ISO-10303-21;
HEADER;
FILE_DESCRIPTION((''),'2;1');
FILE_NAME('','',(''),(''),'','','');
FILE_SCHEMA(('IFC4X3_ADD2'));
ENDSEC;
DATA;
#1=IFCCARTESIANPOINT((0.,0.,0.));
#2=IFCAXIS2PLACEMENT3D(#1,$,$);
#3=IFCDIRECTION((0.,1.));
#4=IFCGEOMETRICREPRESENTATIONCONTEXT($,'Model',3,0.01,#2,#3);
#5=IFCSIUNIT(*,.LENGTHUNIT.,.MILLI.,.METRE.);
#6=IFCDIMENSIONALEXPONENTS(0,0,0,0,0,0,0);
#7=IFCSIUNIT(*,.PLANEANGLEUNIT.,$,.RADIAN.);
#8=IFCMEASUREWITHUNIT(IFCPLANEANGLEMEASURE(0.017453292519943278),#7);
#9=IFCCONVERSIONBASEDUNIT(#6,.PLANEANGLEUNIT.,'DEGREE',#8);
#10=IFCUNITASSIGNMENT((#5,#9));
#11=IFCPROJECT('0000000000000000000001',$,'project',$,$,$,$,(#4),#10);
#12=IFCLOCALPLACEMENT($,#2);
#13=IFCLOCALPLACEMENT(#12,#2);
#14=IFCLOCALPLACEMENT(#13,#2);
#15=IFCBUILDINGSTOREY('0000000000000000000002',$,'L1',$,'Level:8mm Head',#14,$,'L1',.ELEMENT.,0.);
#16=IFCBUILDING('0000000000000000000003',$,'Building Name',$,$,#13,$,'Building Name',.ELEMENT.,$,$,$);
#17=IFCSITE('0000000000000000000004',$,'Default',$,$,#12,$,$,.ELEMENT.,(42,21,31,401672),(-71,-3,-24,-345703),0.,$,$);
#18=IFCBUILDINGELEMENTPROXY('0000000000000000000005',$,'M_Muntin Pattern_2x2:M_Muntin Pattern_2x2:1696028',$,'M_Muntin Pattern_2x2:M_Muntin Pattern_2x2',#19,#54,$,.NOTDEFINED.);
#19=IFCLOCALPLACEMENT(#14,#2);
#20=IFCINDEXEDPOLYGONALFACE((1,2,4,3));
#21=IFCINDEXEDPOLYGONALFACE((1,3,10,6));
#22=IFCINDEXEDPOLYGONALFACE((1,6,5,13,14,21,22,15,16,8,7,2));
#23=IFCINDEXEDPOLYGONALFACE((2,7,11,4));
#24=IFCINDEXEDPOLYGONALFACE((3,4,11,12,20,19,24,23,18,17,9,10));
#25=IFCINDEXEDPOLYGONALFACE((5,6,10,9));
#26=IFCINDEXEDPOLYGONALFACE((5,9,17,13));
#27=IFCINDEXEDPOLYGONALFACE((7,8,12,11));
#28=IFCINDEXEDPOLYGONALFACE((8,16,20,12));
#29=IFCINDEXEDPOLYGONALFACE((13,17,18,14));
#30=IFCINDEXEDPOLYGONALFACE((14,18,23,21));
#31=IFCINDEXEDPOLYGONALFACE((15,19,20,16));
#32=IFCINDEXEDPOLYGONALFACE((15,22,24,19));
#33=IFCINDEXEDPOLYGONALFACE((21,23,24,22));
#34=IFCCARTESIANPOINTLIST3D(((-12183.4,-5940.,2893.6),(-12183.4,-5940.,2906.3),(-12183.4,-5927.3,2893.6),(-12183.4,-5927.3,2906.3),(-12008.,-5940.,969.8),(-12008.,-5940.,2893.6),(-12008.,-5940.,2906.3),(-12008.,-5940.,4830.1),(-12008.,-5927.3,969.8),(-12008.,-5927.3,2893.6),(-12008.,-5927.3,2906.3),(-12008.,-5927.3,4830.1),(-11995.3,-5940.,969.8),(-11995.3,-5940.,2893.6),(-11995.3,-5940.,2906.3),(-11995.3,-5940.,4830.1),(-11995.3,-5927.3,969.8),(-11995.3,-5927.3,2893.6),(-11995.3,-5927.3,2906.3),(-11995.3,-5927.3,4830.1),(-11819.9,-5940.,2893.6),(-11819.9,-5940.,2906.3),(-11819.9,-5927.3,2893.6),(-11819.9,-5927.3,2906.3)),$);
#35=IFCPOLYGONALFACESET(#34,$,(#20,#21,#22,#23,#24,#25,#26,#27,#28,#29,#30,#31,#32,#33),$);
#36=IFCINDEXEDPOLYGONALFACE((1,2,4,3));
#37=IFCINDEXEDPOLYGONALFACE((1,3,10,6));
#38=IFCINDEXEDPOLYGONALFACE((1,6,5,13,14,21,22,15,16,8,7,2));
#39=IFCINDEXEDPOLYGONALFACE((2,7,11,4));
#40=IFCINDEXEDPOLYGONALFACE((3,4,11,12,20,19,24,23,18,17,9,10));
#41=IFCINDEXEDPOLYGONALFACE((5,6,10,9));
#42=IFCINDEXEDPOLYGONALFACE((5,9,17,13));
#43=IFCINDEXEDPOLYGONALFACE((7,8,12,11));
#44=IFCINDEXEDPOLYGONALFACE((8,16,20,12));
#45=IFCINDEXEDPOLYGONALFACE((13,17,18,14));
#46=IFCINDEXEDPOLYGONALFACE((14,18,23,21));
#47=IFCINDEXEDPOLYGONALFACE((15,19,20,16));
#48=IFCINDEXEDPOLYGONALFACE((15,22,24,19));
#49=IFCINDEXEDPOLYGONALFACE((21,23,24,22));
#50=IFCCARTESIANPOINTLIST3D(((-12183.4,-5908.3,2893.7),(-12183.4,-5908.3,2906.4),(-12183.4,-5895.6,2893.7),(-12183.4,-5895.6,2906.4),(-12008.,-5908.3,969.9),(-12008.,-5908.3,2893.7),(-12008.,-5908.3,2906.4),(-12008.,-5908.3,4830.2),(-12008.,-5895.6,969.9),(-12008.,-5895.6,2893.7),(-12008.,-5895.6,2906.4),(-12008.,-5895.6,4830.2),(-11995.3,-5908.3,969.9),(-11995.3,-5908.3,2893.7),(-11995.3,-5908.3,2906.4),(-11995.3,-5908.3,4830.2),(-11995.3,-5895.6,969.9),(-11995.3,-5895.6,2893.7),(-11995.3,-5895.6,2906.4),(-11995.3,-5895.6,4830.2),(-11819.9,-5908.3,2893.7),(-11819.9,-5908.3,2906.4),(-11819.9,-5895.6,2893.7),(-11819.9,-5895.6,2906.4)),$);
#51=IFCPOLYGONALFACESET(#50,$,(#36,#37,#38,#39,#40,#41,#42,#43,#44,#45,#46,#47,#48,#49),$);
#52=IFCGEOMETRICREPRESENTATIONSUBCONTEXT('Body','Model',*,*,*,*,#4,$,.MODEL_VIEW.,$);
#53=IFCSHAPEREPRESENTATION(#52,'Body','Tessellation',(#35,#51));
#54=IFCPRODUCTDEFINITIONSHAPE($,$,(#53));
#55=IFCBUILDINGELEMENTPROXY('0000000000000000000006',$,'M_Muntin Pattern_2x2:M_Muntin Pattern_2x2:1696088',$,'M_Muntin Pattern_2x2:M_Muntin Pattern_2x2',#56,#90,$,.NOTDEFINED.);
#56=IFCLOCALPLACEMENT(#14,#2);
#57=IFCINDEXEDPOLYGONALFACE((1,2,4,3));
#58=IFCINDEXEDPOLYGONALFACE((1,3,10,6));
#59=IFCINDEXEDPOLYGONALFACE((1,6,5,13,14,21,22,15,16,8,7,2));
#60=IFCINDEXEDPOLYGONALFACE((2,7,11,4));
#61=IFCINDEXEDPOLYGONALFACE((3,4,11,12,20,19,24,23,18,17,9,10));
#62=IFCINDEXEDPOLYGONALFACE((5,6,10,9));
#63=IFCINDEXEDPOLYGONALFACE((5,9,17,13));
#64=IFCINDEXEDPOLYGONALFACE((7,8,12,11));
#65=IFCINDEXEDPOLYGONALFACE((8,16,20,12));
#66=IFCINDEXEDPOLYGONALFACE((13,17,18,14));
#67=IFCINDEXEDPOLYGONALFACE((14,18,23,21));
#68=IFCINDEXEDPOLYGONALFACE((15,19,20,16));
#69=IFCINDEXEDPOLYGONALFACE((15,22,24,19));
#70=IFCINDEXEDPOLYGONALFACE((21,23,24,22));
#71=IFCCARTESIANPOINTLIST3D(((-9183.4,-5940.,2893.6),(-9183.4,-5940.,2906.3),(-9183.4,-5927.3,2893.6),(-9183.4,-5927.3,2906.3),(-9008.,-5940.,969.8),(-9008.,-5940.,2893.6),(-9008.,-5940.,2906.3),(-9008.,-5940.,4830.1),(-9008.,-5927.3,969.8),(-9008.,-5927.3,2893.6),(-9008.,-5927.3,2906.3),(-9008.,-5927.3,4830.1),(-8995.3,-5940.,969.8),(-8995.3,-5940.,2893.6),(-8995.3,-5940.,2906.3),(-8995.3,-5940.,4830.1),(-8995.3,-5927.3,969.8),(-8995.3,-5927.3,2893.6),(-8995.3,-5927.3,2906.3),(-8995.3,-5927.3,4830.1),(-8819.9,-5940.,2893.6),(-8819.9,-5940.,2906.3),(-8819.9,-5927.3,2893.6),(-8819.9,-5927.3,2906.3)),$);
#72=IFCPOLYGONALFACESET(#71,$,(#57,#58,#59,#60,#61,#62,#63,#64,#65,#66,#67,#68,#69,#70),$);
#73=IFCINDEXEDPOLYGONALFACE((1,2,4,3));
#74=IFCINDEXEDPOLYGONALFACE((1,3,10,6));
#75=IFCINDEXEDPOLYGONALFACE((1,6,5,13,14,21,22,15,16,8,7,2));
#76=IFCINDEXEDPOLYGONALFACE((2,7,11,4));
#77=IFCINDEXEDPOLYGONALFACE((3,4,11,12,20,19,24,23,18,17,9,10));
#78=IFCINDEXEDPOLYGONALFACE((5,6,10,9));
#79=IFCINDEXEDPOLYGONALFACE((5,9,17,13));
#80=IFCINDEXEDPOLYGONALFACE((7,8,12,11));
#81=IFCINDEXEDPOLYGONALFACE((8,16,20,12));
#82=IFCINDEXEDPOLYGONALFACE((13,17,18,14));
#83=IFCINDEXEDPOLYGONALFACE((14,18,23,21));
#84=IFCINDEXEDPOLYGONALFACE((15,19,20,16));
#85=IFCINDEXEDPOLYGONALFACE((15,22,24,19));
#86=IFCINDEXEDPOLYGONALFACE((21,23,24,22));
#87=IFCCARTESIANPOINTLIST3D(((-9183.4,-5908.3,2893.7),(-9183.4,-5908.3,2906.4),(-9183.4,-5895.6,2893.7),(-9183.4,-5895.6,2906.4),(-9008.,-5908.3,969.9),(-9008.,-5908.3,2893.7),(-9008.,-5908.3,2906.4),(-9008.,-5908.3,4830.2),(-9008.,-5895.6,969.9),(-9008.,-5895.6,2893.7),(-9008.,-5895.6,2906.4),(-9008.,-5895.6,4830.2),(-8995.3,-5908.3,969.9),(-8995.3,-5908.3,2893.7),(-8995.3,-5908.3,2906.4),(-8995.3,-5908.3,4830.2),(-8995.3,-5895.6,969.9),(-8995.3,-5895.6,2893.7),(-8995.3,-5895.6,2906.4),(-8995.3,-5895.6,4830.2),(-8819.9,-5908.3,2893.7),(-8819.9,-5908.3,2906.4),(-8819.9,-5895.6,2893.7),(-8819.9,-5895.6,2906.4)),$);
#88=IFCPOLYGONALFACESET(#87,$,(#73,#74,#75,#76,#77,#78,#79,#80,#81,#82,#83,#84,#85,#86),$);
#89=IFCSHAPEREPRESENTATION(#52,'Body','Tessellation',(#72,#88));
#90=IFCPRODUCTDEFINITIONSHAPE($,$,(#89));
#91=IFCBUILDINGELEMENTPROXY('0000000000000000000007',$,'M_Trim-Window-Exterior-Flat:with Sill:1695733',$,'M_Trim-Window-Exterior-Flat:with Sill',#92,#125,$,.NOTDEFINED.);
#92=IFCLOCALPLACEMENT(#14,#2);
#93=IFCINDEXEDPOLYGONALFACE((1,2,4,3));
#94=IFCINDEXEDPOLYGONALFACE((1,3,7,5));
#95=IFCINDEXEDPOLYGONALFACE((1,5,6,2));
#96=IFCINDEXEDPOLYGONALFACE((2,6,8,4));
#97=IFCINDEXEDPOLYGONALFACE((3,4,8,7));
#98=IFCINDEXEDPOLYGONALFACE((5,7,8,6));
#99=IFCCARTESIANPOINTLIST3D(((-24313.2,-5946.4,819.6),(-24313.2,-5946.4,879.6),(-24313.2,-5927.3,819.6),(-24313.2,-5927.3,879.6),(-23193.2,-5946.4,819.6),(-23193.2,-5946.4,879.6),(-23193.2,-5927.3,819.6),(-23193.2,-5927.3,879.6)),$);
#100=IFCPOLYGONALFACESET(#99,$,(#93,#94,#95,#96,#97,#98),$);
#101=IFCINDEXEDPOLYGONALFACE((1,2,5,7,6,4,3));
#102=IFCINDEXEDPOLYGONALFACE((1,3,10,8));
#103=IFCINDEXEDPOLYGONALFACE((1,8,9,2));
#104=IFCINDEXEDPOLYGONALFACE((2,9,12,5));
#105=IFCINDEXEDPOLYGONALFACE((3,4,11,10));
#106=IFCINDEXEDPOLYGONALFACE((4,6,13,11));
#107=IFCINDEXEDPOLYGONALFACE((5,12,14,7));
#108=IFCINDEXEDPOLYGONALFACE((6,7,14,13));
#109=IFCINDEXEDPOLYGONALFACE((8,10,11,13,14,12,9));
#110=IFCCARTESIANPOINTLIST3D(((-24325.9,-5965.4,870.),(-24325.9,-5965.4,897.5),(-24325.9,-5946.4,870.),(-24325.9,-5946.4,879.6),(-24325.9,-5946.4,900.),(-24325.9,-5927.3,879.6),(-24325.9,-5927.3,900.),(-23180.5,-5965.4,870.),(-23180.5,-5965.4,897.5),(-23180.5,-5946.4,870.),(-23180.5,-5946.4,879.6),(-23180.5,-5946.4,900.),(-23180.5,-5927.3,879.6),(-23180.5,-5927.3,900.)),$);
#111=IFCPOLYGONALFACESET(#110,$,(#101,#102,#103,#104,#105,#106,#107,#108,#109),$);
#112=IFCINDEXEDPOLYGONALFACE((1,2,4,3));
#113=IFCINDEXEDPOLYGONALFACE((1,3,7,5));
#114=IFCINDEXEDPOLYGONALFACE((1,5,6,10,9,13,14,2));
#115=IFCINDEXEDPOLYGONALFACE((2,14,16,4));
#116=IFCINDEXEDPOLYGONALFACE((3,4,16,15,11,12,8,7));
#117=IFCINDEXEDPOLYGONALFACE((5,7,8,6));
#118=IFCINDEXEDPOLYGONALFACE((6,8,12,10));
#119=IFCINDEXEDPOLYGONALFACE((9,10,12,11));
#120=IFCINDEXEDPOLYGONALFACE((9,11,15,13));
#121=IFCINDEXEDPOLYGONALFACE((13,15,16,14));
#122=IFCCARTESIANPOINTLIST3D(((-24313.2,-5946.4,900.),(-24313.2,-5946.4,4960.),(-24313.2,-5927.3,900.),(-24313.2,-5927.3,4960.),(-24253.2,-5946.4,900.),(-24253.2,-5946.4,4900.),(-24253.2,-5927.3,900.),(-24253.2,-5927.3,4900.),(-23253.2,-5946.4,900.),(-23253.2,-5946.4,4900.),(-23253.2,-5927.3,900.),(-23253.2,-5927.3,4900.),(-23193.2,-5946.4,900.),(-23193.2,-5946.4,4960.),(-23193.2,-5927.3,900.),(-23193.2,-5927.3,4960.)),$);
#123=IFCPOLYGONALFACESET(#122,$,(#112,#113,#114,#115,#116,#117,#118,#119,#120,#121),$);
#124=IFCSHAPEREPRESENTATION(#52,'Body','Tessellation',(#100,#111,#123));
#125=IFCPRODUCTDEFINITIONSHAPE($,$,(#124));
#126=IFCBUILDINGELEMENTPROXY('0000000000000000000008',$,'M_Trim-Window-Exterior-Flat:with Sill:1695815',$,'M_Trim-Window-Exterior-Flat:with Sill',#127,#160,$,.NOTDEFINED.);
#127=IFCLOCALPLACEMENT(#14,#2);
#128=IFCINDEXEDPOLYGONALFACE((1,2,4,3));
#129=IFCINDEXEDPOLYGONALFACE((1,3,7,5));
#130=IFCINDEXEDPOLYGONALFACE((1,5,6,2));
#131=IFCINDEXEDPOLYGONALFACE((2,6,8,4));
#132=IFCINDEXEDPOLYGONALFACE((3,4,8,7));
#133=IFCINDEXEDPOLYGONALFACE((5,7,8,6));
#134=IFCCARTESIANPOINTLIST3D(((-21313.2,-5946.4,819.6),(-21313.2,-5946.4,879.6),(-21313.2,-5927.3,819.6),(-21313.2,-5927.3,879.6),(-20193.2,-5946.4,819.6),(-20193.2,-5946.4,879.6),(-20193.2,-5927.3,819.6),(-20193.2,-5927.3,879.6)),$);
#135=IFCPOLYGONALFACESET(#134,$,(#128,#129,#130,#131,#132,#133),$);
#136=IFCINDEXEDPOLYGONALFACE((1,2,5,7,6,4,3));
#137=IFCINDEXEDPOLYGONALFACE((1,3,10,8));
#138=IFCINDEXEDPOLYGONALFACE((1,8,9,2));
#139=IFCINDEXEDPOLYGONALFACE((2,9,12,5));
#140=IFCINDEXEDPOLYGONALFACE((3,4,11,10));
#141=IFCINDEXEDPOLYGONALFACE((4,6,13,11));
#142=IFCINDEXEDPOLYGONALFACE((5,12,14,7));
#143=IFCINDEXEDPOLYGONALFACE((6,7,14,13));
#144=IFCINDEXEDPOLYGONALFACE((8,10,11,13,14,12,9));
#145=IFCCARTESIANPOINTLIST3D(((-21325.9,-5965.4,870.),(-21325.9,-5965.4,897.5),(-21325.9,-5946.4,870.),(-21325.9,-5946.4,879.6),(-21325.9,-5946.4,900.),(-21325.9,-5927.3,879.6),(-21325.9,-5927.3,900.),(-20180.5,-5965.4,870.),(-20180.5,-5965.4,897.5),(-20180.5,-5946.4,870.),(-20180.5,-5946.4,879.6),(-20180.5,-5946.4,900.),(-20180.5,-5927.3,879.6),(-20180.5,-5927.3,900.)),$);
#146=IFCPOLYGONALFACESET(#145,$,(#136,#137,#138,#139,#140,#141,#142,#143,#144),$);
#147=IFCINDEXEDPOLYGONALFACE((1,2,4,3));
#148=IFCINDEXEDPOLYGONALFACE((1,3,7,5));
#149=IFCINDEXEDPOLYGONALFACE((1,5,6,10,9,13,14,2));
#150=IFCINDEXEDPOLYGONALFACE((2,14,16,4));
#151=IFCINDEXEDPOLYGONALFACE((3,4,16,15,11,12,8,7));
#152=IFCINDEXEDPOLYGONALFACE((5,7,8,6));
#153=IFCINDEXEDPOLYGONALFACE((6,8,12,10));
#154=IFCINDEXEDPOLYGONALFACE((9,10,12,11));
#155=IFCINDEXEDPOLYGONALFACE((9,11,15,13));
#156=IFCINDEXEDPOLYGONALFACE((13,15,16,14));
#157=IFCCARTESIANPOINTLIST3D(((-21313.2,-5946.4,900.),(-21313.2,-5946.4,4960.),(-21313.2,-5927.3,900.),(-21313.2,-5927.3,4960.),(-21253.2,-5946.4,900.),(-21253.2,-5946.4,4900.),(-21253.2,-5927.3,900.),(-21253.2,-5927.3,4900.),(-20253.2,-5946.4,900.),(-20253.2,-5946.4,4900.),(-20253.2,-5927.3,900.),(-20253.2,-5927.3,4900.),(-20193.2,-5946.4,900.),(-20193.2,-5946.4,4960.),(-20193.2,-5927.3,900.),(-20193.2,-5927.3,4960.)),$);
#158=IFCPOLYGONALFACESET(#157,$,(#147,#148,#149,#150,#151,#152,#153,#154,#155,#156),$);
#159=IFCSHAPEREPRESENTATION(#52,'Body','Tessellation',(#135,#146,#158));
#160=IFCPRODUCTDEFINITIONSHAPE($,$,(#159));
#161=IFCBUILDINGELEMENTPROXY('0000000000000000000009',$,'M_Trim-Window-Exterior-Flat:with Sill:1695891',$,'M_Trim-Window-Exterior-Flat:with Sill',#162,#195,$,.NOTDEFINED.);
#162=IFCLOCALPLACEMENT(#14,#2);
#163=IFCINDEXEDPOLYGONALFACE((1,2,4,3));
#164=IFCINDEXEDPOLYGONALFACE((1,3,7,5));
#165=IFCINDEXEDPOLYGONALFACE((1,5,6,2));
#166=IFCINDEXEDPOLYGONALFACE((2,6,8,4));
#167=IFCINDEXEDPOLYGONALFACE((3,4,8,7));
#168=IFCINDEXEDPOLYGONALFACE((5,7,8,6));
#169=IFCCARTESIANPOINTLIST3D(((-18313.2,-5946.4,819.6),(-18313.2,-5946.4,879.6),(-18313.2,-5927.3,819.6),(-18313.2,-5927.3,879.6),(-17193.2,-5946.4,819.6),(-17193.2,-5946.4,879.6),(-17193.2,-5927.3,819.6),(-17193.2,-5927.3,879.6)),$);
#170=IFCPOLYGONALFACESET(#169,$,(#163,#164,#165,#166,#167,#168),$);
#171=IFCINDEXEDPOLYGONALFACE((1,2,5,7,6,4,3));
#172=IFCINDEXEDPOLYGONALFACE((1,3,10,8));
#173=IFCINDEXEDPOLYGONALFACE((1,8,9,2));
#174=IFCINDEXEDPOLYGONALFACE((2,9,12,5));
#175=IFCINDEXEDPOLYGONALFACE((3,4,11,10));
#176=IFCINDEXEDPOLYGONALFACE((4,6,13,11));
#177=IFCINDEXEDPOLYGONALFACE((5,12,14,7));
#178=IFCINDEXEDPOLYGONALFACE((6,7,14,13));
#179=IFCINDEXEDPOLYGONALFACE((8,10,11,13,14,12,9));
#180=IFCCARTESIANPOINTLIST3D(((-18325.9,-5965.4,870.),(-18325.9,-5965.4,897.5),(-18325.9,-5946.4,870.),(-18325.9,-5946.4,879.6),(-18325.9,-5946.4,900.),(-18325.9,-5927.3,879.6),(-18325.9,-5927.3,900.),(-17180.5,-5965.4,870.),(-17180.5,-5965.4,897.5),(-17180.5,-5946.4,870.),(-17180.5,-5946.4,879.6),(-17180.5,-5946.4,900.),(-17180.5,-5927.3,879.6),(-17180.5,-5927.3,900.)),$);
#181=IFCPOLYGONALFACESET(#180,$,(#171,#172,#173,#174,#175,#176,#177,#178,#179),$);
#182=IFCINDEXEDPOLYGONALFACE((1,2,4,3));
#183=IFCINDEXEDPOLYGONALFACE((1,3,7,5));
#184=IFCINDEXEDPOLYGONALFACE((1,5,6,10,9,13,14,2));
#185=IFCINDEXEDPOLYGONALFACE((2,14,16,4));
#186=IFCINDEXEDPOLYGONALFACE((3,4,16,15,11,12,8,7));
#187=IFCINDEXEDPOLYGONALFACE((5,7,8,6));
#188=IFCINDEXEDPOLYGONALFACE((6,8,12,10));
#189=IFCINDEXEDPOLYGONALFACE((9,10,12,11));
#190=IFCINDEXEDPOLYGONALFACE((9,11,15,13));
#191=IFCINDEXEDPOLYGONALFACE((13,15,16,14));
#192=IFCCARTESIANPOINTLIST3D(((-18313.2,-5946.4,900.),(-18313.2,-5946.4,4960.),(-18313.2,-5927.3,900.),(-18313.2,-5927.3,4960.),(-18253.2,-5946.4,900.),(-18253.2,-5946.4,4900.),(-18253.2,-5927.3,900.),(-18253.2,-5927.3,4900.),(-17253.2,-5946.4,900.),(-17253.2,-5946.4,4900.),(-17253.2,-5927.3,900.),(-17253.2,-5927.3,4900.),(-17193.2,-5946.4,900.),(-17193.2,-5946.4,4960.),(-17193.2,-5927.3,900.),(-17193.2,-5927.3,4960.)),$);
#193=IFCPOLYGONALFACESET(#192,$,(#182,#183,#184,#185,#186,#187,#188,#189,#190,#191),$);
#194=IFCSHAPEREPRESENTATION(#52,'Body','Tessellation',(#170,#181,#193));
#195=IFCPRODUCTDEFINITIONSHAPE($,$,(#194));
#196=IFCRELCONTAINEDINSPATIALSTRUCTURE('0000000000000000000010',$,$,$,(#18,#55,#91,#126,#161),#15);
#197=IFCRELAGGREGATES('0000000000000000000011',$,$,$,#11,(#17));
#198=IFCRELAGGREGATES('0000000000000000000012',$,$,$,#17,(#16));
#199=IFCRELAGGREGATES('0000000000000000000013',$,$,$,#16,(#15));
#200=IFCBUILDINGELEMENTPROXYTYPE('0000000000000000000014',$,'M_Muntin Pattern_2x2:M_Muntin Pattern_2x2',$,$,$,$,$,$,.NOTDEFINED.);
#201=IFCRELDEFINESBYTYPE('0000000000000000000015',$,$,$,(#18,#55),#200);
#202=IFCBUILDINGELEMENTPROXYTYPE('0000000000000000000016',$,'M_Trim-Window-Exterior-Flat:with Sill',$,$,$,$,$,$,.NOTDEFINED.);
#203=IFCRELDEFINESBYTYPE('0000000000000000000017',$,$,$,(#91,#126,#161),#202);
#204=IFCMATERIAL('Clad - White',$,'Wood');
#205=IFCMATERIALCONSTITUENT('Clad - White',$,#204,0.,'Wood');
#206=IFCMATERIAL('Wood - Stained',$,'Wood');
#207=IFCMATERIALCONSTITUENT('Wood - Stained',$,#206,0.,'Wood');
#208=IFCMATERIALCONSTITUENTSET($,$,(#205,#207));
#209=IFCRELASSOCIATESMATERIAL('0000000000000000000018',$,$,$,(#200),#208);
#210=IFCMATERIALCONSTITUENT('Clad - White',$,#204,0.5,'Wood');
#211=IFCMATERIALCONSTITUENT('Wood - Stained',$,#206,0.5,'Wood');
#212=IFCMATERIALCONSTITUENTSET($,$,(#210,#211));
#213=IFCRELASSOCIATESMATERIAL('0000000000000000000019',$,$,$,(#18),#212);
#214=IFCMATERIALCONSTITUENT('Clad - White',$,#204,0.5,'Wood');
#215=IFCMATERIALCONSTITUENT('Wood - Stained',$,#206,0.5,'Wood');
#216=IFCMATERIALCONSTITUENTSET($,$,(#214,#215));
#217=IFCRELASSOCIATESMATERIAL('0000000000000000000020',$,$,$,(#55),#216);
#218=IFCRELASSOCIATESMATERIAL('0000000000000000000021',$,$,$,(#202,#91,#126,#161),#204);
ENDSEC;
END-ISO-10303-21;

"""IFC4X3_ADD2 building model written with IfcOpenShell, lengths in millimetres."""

from ifc_helpers import new_model, entity, si_unit, converted_unit, direction, frame, frame_2d, origin, place, context, subcontext, project, spatial, polyline, rectangle, outline, extrude, source, transform, mapped, material, constituent, constituent_set, type_object, type_shapes, element, save


model = new_model("IFC4X3_ADD2")

# Units and contexts
model_context = context("Model", 3, precision=0.01, world=origin(), true_north=direction((0.0, 1.0)))
body_context = subcontext(model_context, "Body", "Model", "MODEL_VIEW")
ifc_project = project(units=[si_unit("LENGTHUNIT", "METRE", prefix="MILLI"), converted_unit("PLANEANGLEUNIT", "DEGREE", entity("IfcPlaneAngleMeasure", 0.017453292519943278), si_unit("PLANEANGLEUNIT", "RADIAN"), dimensions=[0, 0, 0, 0, 0, 0, 0])], contexts=[model_context])

# Site, building, storey
site_placement = place(None, origin())
site = spatial("IfcSite", under=ifc_project, at=site_placement, Name="Default", CompositionType="ELEMENT", RefLatitude=(42, 21, 31, 401672), RefLongitude=(-71, -3, -24, -345703), RefElevation=0.0)
building_placement = place(site_placement, origin())
building = spatial("IfcBuilding", under=site, at=building_placement, Name="Building Name", LongName="Building Name", CompositionType="ELEMENT")
storey_placement = place(building_placement, origin())
storey = spatial("IfcBuildingStorey", under=building, at=storey_placement, Name="L1", ObjectType="Level:8mm Head", LongName="L1", CompositionType="ELEMENT", Elevation=0.0)

# Building element proxies
ifc_material_1 = material(Name="Clad - White", Category="Wood")
ifc_material_2 = material(Name="Wood - Stained", Category="Wood")
ifc_constituent_1 = constituent(ifc_material_1, Name="Clad - White", Category="Wood", fraction=0.0)
ifc_constituent_2 = constituent(ifc_material_2, Name="Wood - Stained", Category="Wood", fraction=0.0)
ifc_constituent_set_1 = constituent_set(constituents=[ifc_constituent_1, ifc_constituent_2])
building_element_proxy_type_1 = type_object("IfcBuildingElementProxyType", Name="M_Muntin Pattern_2x2:M_Muntin Pattern_2x2", PredefinedType="NOTDEFINED", material=ifc_constituent_set_1)
shared_shape_1 = source(origin(), body_context, "Body", "SweptSolid", [
    extrude(outline(polyline([(6.4, -6.4), (1930.1, -6.4), (1930.1, 6.3), (6.4, 6.3), (6.4, 181.7), (-6.3, 181.7), (-6.3, 6.3), (-1930.2, 6.3), (-1930.2, -6.4), (-6.3, -6.4), (-6.3, -181.7), (6.4, -181.7), (6.4, -6.4)])), frame((0.0, -22.2, 1930.1), z_axis=(0.0, 1.0, 0.0), x_axis=(0.0, 0.0, 1.0)), (0.0, 0.0, 1.0), 12.7),
    extrude(outline(polyline([(6.4, -6.4), (1930.2, -6.4), (1930.2, 6.3), (6.4, 6.3), (6.4, 181.7), (-6.3, 181.7), (-6.3, 6.3), (-1930.2, 6.3), (-1930.2, -6.4), (-6.3, -6.4), (-6.3, -181.7), (6.4, -181.7), (6.4, -6.4)])), frame((0.0, 9.5, 1930.2), z_axis=(0.0, 1.0, 0.0), x_axis=(0.0, 0.0, 1.0)), (0.0, 0.0, 1.0), 12.7),
])
type_shapes(building_element_proxy_type_1, [shared_shape_1])
ifc_constituent_3 = constituent(ifc_material_1, Name="Clad - White", Category="Wood", fraction=0.5)
ifc_constituent_4 = constituent(ifc_material_2, Name="Wood - Stained", Category="Wood", fraction=0.5)
ifc_constituent_set_2 = constituent_set(constituents=[ifc_constituent_3, ifc_constituent_4])
proxy_1_placement = place(storey_placement, frame((-12001.6, -5917.8, 969.9)))
element("IfcBuildingElementProxy", 1, at=proxy_1_placement, inside=storey, type_object=building_element_proxy_type_1, material=ifc_constituent_set_2, Name="M_Muntin Pattern_2x2:M_Muntin Pattern_2x2:1696028", ObjectType="M_Muntin Pattern_2x2:M_Muntin Pattern_2x2", PredefinedType="NOTDEFINED", context=body_context, shape_type="MappedRepresentation", body=[
    mapped(shared_shape_1, transform((0.0, 0.0, 0.0), scale=1.0)),
])
ifc_constituent_5 = constituent(ifc_material_1, Name="Clad - White", Category="Wood", fraction=0.5)
ifc_constituent_6 = constituent(ifc_material_2, Name="Wood - Stained", Category="Wood", fraction=0.5)
ifc_constituent_set_3 = constituent_set(constituents=[ifc_constituent_5, ifc_constituent_6])
proxy_2_placement = place(storey_placement, frame((-9001.6, -5917.8, 969.9)))
element("IfcBuildingElementProxy", 2, at=proxy_2_placement, inside=storey, type_object=building_element_proxy_type_1, material=ifc_constituent_set_3, Name="M_Muntin Pattern_2x2:M_Muntin Pattern_2x2:1696088", ObjectType="M_Muntin Pattern_2x2:M_Muntin Pattern_2x2", PredefinedType="NOTDEFINED", context=body_context, shape_type="MappedRepresentation", body=[
    mapped(shared_shape_1, transform((0.0, 0.0, 0.0), scale=1.0)),
])
building_element_proxy_type_2 = type_object("IfcBuildingElementProxyType", Name="M_Trim-Window-Exterior-Flat:with Sill", PredefinedType="NOTDEFINED", material=ifc_material_1)
shared_shape_2 = source(origin(), body_context, "Body", "SweptSolid", [
    extrude(rectangle(XDim=1120.0, YDim=60.0, at=frame_2d((0.0, 0.0), x_axis=(1.0, 0.0))), frame((0.0, -4050.4, 0.0), z_axis=(0.0, 0.0, 1.0), x_axis=(-1.0, 0.0, 0.0)), (0.0, 0.0, 1.0), 19.0),
    extrude(outline(polyline([(-19.0, -15.2), (0.0, -15.2), (0.0, -5.7), (19.0, -5.7), (19.0, 14.8), (0.0, 14.8), (-19.0, 12.3), (-19.0, -15.2)])), frame((-572.7, -4014.8, 19.0), z_axis=(1.0, 0.0, 0.0), x_axis=(0.0, 0.0, -1.0)), (0.0, 0.0, 1.0), 1145.4),
    extrude(outline(polyline([(-2045.0, -560.0), (2015.0, -560.0), (2015.0, -500.0), (-1985.0, -500.0), (-1985.0, 500.0), (2015.0, 500.0), (2015.0, 560.0), (-2045.0, 560.0), (-2045.0, -560.0)])), frame((0.0, -1985.0, 0.0), z_axis=(0.0, 0.0, 1.0), x_axis=(0.0, -1.0, 0.0)), (0.0, 0.0, 1.0), 19.0),
])
type_shapes(building_element_proxy_type_2, [shared_shape_2])
for number, where, z_axis, x_axis, name in (
    (3, (-23753.2, -5927.3, 4900.0), (0.0, -1.0, 0.0), (1.0, 0.0, 0.0), "M_Trim-Window-Exterior-Flat:with Sill:1695733"),
    (4, (-20753.2, -5927.3, 4900.0), (0.0, -1.0, 0.0), (1.0, 0.0, 0.0), "M_Trim-Window-Exterior-Flat:with Sill:1695815"),
    (5, (-17753.2, -5927.3, 4900.0), (0.0, -1.0, 0.0), (1.0, 0.0, 0.0), "M_Trim-Window-Exterior-Flat:with Sill:1695891"),
):
    element("IfcBuildingElementProxy", number, at=place(storey_placement, frame(where, z_axis=z_axis, x_axis=x_axis)), inside=storey, type_object=building_element_proxy_type_2, material=ifc_material_1, Name=name, ObjectType="M_Trim-Window-Exterior-Flat:with Sill", PredefinedType="NOTDEFINED", context=body_context, shape_type="MappedRepresentation", body=[
        mapped(shared_shape_2, transform((0.0, 0.0, 0.0), scale=1.0)),
    ])

save(model, "model.ifc")
